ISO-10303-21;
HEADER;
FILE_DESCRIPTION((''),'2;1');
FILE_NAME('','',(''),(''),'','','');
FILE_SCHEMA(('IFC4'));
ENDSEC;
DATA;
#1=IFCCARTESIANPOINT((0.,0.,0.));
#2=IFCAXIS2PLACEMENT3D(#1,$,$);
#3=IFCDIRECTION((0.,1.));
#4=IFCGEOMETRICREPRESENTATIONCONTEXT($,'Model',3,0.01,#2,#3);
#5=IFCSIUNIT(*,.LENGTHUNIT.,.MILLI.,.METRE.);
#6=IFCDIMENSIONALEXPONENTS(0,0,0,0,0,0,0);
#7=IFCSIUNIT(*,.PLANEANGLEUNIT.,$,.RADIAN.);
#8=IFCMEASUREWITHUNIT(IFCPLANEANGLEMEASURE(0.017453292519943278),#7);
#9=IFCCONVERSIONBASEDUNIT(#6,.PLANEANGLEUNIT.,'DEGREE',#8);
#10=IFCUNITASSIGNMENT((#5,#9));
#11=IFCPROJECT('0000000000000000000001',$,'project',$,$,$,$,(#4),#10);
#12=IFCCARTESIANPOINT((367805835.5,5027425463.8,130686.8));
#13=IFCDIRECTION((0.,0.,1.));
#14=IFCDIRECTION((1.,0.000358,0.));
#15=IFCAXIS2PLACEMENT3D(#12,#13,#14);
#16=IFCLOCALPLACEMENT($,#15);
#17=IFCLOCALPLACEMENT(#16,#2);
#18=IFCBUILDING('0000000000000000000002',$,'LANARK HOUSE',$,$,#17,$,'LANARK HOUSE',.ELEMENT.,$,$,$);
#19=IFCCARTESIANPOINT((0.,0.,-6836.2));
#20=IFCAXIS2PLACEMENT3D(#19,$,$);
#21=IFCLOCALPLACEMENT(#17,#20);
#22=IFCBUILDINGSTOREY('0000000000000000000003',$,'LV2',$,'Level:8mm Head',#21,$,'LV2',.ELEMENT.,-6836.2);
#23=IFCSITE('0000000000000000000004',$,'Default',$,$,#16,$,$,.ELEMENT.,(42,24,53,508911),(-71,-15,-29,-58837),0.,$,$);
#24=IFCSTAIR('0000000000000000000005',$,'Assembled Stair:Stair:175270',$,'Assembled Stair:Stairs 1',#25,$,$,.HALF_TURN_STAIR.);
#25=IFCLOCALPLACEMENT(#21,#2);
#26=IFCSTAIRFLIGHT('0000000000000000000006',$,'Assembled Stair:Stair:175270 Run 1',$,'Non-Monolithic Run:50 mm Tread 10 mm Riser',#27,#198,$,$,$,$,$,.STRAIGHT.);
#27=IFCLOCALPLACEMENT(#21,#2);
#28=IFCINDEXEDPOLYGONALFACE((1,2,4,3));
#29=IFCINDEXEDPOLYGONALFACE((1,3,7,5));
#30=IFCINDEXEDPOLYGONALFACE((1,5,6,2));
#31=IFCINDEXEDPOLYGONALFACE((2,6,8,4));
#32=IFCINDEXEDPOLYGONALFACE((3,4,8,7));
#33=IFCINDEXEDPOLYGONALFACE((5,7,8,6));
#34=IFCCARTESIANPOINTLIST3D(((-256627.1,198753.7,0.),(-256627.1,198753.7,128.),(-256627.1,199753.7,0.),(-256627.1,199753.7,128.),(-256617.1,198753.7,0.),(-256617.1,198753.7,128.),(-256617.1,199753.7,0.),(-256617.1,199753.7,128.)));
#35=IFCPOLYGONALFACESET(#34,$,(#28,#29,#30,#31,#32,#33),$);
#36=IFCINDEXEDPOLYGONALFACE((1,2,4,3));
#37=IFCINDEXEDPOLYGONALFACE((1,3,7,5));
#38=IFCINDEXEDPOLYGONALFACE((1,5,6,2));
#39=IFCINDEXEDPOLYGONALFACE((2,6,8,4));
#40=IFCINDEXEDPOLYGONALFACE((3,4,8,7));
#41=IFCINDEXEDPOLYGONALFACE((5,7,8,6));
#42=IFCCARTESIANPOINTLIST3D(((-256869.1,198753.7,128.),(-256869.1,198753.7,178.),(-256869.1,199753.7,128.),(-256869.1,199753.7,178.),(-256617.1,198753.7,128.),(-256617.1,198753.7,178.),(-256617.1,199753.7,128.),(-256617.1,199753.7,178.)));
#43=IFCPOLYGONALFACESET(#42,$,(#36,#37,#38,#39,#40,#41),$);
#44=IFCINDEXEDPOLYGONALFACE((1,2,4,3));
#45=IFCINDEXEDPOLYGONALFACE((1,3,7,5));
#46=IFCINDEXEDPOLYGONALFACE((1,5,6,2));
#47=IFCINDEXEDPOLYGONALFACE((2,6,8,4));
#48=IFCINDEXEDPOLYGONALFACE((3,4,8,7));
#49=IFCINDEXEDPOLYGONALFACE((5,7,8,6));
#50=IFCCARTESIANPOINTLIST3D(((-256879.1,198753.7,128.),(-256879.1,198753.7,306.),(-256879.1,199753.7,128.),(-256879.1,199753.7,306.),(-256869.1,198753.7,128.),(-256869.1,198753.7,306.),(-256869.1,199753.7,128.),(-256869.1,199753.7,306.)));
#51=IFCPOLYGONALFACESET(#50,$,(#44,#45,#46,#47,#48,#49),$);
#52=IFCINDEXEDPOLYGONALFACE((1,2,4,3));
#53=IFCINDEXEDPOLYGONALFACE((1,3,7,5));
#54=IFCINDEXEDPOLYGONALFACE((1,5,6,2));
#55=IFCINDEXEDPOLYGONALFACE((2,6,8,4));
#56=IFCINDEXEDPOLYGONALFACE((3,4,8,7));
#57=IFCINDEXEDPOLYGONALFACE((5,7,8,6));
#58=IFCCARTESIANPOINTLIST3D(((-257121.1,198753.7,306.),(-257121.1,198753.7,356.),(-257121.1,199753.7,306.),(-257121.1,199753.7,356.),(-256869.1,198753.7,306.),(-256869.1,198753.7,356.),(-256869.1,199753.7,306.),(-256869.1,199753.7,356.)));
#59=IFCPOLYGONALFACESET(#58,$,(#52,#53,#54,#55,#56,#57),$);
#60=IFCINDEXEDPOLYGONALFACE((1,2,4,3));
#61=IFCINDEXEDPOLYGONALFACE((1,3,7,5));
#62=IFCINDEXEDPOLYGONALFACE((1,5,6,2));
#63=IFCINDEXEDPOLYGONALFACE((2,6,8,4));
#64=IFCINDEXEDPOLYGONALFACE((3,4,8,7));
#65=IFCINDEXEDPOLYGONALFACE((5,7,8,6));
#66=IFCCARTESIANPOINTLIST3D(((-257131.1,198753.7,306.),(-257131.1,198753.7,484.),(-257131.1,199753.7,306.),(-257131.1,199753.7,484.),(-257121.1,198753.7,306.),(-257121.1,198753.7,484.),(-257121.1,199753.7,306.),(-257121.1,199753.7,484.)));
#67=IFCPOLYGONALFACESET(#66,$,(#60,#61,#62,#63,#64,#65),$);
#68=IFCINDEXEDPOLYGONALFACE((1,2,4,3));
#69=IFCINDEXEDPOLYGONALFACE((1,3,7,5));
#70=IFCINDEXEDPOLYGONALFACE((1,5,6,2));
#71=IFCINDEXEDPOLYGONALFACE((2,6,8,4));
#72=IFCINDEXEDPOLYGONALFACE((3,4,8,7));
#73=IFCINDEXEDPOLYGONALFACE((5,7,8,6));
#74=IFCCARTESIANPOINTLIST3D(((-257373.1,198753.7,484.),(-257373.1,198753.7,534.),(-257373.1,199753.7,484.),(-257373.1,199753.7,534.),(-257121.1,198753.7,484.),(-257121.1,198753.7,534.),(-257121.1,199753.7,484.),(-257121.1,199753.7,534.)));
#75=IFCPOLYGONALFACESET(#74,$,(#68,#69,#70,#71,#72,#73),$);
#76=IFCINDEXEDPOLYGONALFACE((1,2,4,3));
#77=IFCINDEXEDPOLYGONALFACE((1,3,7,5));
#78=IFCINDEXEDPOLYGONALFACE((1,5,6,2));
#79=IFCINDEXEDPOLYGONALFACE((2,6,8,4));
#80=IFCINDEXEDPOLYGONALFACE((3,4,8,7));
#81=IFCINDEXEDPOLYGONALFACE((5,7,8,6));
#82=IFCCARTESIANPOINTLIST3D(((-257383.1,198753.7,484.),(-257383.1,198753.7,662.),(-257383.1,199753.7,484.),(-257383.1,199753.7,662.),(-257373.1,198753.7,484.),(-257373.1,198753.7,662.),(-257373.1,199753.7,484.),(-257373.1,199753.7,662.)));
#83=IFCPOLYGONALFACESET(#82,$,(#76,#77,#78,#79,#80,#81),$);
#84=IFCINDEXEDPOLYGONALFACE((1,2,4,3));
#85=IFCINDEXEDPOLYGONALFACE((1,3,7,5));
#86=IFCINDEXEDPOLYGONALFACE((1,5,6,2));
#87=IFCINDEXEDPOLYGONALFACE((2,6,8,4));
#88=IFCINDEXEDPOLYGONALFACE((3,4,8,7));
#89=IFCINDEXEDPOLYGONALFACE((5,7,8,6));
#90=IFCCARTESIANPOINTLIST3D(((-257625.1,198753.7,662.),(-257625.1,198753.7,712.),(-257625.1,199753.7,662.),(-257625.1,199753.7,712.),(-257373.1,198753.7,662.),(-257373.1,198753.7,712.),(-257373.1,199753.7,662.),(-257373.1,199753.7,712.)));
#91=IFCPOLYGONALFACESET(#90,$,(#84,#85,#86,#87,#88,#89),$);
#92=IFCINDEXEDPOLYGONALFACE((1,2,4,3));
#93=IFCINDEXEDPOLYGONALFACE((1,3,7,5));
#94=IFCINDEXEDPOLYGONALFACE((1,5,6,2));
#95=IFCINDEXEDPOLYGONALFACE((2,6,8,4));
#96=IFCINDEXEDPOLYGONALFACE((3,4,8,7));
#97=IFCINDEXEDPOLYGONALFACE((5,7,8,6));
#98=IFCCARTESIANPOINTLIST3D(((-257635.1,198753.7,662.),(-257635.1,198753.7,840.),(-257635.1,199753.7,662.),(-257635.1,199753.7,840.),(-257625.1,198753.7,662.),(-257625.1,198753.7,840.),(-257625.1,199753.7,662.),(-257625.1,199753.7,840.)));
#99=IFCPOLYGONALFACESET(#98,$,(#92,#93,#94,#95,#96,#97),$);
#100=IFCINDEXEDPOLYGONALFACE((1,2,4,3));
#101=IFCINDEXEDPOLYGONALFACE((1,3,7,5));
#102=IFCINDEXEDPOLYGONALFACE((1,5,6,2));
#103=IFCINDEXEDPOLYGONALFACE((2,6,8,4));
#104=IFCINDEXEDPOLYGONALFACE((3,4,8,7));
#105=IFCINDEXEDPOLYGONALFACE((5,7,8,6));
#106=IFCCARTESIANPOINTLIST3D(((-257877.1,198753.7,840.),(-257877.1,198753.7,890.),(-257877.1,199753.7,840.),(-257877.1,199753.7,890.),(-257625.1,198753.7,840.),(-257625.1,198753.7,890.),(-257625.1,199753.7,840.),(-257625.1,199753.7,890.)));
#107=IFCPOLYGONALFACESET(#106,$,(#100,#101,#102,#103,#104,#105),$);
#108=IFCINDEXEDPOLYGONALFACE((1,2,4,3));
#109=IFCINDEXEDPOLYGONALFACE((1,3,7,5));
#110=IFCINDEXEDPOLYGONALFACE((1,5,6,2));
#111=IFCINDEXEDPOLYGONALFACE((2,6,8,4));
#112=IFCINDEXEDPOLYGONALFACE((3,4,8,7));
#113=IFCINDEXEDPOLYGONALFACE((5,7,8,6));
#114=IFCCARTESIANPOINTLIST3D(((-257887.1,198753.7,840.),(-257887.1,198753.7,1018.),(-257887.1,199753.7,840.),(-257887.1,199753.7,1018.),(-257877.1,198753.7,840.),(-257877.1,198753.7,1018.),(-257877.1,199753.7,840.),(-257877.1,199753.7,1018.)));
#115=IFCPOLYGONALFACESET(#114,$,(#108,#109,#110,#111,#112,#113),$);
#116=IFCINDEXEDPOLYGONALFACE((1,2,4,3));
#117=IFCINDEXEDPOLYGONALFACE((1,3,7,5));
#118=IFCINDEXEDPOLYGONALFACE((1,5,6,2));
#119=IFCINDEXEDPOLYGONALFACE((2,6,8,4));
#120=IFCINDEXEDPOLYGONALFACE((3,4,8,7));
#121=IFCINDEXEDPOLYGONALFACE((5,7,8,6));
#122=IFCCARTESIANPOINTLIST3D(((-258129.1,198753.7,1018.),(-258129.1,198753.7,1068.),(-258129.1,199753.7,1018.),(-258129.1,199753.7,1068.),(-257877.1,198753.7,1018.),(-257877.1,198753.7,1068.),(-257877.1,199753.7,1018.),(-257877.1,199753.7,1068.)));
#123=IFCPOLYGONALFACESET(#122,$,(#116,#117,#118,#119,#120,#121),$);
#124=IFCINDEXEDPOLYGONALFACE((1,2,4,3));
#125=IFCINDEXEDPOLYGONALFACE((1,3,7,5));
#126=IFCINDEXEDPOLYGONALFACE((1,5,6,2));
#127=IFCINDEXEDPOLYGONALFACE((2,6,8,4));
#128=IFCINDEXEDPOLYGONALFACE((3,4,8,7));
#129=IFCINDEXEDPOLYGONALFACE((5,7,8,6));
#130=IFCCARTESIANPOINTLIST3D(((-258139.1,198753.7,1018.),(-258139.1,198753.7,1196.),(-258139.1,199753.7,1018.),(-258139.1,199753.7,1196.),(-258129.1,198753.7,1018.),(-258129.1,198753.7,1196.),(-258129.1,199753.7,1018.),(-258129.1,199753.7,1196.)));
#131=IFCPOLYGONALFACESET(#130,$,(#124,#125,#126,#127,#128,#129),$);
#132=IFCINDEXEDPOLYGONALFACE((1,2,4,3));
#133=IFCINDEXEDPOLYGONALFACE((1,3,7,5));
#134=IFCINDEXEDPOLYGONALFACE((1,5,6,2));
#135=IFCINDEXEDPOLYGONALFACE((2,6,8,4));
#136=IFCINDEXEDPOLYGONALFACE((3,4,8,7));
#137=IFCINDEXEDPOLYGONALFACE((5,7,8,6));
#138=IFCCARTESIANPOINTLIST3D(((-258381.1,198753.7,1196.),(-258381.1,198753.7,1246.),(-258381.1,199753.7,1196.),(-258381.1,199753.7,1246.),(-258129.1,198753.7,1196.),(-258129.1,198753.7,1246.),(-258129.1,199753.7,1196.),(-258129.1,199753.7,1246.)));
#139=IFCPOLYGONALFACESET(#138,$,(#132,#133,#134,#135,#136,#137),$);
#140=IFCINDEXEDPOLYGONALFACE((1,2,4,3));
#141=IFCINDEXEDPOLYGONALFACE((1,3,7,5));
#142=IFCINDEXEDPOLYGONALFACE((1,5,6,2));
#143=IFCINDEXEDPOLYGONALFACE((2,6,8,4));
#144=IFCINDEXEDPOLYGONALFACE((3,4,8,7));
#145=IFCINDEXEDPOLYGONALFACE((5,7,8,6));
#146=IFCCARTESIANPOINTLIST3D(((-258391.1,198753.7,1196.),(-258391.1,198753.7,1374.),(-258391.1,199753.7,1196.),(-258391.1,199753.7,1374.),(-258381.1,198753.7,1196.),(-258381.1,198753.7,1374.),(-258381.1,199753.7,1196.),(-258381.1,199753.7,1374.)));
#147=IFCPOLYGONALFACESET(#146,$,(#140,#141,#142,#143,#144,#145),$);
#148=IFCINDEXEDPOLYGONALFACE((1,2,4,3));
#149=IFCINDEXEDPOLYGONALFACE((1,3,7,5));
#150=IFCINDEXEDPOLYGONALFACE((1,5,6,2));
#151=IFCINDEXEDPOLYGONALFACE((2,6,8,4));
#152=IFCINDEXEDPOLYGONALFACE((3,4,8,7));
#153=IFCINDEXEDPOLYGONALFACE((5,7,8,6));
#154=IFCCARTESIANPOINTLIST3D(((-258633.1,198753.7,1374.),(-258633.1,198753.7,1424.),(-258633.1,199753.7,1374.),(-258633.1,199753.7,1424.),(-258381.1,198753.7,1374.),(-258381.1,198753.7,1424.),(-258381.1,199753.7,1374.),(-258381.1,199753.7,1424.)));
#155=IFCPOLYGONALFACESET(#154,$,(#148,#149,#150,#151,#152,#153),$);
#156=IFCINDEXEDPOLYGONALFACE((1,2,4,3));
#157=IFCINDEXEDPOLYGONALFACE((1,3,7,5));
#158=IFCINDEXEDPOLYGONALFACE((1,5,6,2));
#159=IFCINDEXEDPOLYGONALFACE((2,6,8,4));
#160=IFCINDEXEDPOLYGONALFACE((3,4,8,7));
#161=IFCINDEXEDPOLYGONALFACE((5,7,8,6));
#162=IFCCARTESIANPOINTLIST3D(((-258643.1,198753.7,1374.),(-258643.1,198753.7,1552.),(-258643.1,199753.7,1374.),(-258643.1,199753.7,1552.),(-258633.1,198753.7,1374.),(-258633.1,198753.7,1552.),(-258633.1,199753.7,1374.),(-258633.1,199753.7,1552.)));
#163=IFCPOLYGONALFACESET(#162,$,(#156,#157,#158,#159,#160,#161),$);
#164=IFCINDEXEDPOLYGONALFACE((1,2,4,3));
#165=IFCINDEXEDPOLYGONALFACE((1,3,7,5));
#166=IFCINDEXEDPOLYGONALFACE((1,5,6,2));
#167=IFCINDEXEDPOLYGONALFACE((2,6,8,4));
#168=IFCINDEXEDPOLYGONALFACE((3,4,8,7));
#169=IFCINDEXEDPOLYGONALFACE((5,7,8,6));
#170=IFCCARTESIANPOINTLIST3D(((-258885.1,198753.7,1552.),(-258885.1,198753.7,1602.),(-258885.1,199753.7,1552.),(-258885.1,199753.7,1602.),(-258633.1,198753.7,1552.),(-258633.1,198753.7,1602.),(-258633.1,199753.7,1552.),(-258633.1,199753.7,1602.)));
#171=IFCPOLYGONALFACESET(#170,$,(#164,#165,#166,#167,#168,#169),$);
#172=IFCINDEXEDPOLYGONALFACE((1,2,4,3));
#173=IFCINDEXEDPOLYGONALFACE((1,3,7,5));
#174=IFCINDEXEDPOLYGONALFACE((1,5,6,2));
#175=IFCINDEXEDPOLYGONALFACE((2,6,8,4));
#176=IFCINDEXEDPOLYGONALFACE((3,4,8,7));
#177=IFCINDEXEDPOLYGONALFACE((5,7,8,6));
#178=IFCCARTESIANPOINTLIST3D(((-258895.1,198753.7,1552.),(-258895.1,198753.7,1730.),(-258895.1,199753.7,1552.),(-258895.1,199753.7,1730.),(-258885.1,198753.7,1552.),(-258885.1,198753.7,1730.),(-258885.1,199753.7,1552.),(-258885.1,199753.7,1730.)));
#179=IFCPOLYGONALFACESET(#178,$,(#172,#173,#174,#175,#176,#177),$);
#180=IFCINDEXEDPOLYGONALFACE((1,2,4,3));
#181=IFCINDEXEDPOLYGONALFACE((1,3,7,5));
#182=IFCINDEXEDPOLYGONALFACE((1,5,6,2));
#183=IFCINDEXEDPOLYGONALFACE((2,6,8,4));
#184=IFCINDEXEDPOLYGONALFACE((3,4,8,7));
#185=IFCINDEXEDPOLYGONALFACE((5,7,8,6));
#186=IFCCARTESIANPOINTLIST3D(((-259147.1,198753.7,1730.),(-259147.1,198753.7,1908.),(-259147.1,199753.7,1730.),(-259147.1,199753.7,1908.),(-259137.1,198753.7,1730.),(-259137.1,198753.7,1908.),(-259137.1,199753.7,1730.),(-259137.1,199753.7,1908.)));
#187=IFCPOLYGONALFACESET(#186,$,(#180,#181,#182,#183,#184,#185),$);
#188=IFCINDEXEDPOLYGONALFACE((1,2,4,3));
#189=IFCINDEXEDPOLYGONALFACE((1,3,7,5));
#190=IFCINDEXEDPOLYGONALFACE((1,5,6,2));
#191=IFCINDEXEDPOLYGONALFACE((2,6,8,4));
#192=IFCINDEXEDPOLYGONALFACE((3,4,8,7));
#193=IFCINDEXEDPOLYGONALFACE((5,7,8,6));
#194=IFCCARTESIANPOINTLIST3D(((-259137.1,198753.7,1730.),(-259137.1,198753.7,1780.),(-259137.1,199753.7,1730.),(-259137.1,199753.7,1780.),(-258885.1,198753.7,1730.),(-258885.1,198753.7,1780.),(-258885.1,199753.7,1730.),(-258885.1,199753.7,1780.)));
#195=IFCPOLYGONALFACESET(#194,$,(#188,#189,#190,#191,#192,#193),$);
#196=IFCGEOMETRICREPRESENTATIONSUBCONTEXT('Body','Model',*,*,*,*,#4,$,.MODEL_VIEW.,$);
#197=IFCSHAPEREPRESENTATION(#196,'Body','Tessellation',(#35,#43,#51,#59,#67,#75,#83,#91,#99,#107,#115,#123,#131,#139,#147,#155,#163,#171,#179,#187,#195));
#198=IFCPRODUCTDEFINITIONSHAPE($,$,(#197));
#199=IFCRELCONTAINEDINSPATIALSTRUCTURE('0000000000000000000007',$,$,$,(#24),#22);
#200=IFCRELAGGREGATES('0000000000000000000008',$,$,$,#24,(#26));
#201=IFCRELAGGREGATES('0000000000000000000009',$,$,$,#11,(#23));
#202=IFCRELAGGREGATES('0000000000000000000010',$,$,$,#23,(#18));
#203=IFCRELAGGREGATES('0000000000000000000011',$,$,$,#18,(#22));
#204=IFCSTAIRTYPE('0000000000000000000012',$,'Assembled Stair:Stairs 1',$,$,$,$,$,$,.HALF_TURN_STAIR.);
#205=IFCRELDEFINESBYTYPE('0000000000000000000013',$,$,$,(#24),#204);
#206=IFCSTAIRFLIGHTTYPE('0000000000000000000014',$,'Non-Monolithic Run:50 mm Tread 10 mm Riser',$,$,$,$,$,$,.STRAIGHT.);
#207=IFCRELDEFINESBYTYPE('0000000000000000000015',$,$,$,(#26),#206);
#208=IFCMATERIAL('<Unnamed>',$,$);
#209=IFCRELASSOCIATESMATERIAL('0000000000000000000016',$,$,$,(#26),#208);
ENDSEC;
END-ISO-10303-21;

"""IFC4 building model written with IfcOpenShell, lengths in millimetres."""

from ifc_helpers import new_model, entity, si_unit, converted_unit, direction, frame, origin, place, context, subcontext, project, spatial, indexed_curve, outline, extrude, material, type_object, element, aggregate, save


model = new_model("IFC4")

# Units and contexts
model_context = context("Model", 3, precision=0.01, world=origin(), true_north=direction((0.0, 1.0)))
body_context = subcontext(model_context, "Body", "Model", "MODEL_VIEW")
ifc_project = project(units=[si_unit("LENGTHUNIT", "METRE", prefix="MILLI"), converted_unit("PLANEANGLEUNIT", "DEGREE", entity("IfcPlaneAngleMeasure", 0.017453292519943278), si_unit("PLANEANGLEUNIT", "RADIAN"), dimensions=[0, 0, 0, 0, 0, 0, 0])], contexts=[model_context])

# Site, building, storey
site_placement = place(None, frame((367805835.5, 5027425463.8, 130686.8), z_axis=(0.0, 0.0, 1.0), x_axis=(1.0, 0.000358, 0.0)))
site = spatial("IfcSite", under=ifc_project, at=site_placement, Name="Default", CompositionType="ELEMENT", RefLatitude=(42, 24, 53, 508911), RefLongitude=(-71, -15, -29, -58837), RefElevation=0.0)
building_placement = place(site_placement, origin())
building = spatial("IfcBuilding", under=site, at=building_placement, Name="LANARK HOUSE", LongName="LANARK HOUSE", CompositionType="ELEMENT")
storey_placement = place(building_placement, frame((0.0, 0.0, -6836.2)))
storey = spatial("IfcBuildingStorey", under=building, at=storey_placement, Name="LV2", ObjectType="Level:8mm Head", LongName="LV2", CompositionType="ELEMENT", Elevation=-6836.2)

# Stair
stair_type = type_object("IfcStairType", Name="Assembled Stair:Stairs 1", PredefinedType="HALF_TURN_STAIR")
stair_placement = place(storey_placement, origin())
stair = element("IfcStair", 1, at=stair_placement, inside=storey, type_object=stair_type, Name="Assembled Stair:Stair:175270", ObjectType="Assembled Stair:Stairs 1", PredefinedType="HALF_TURN_STAIR")
ifc_material_1 = material(Name="<Unnamed>")

# Stair flight
stair_flight_type = type_object("IfcStairFlightType", Name="Non-Monolithic Run:50 mm Tread 10 mm Riser", PredefinedType="STRAIGHT")
stair_flight_placement = place(stair_placement, frame((-259147.1, 198753.7, 0.0)))
stair_flight = element("IfcStairFlight", 2, at=stair_flight_placement, type_object=stair_flight_type, material=ifc_material_1, Name="Assembled Stair:Stair:175270 Run 1", ObjectType="Non-Monolithic Run:50 mm Tread 10 mm Riser", PredefinedType="STRAIGHT", context=body_context, shape_type="SweptSolid", body=[
    extrude(outline(indexed_curve([(-500.0, -5.0), (500.0, -5.0), (500.0, 5.0), (-500.0, 5.0), (-500.0, -5.0)], self_intersect=False)), frame((2525.0, 500.0, 0.0), z_axis=(0.0, 0.0, 1.0), x_axis=(0.0, -1.0, 0.0)), (0.0, 0.0, 1.0), 128.0),
    extrude(outline(indexed_curve([(-126.0, -500.0), (126.0, -500.0), (126.0, 500.0), (-126.0, 500.0), (-126.0, -500.0)], self_intersect=False)), frame((2404.0, 500.0, 128.0)), (0.0, 0.0, 1.0), 50.0),
    extrude(outline(indexed_curve([(-500.0, -5.0), (500.0, -5.0), (500.0, 5.0), (-500.0, 5.0), (-500.0, -5.0)], self_intersect=False)), frame((2273.0, 500.0, 128.0), z_axis=(0.0, 0.0, 1.0), x_axis=(0.0, -1.0, 0.0)), (0.0, 0.0, 1.0), 178.0),
    extrude(outline(indexed_curve([(-126.0, -500.0), (126.0, -500.0), (126.0, 500.0), (-126.0, 500.0), (-126.0, -500.0)], self_intersect=False)), frame((2152.0, 500.0, 306.0)), (0.0, 0.0, 1.0), 50.0),
    extrude(outline(indexed_curve([(-500.0, -5.0), (500.0, -5.0), (500.0, 5.0), (-500.0, 5.0), (-500.0, -5.0)], self_intersect=False)), frame((2021.0, 500.0, 306.0), z_axis=(0.0, 0.0, 1.0), x_axis=(0.0, -1.0, 0.0)), (0.0, 0.0, 1.0), 178.0),
    extrude(outline(indexed_curve([(-126.0, -500.0), (126.0, -500.0), (126.0, 500.0), (-126.0, 500.0), (-126.0, -500.0)], self_intersect=False)), frame((1900.0, 500.0, 484.0)), (0.0, 0.0, 1.0), 50.0),
    extrude(outline(indexed_curve([(-500.0, -5.0), (500.0, -5.0), (500.0, 5.0), (-500.0, 5.0), (-500.0, -5.0)], self_intersect=False)), frame((1769.0, 500.0, 484.0), z_axis=(0.0, 0.0, 1.0), x_axis=(0.0, -1.0, 0.0)), (0.0, 0.0, 1.0), 178.0),
    extrude(outline(indexed_curve([(-126.0, -500.0), (126.0, -500.0), (126.0, 500.0), (-126.0, 500.0), (-126.0, -500.0)], self_intersect=False)), frame((1648.0, 500.0, 662.0)), (0.0, 0.0, 1.0), 50.0),
    extrude(outline(indexed_curve([(-500.0, -5.0), (500.0, -5.0), (500.0, 5.0), (-500.0, 5.0), (-500.0, -5.0)], self_intersect=False)), frame((1517.0, 500.0, 662.0), z_axis=(0.0, 0.0, 1.0), x_axis=(0.0, -1.0, 0.0)), (0.0, 0.0, 1.0), 178.0),
    extrude(outline(indexed_curve([(-126.0, -500.0), (126.0, -500.0), (126.0, 500.0), (-126.0, 500.0), (-126.0, -500.0)], self_intersect=False)), frame((1396.0, 500.0, 840.0)), (0.0, 0.0, 1.0), 50.0),
    extrude(outline(indexed_curve([(-500.0, -5.0), (500.0, -5.0), (500.0, 5.0), (-500.0, 5.0), (-500.0, -5.0)], self_intersect=False)), frame((1265.0, 500.0, 840.0), z_axis=(0.0, 0.0, 1.0), x_axis=(0.0, -1.0, 0.0)), (0.0, 0.0, 1.0), 178.0),
    extrude(outline(indexed_curve([(-126.0, -500.0), (126.0, -500.0), (126.0, 500.0), (-126.0, 500.0), (-126.0, -500.0)], self_intersect=False)), frame((1144.0, 500.0, 1018.0)), (0.0, 0.0, 1.0), 50.0),
    extrude(outline(indexed_curve([(-500.0, -5.0), (500.0, -5.0), (500.0, 5.0), (-500.0, 5.0), (-500.0, -5.0)], self_intersect=False)), frame((1013.0, 500.0, 1018.0), z_axis=(0.0, 0.0, 1.0), x_axis=(0.0, -1.0, 0.0)), (0.0, 0.0, 1.0), 178.0),
    extrude(outline(indexed_curve([(-126.0, -500.0), (126.0, -500.0), (126.0, 500.0), (-126.0, 500.0), (-126.0, -500.0)], self_intersect=False)), frame((892.0, 500.0, 1196.0)), (0.0, 0.0, 1.0), 50.0),
    extrude(outline(indexed_curve([(-500.0, -5.0), (500.0, -5.0), (500.0, 5.0), (-500.0, 5.0), (-500.0, -5.0)], self_intersect=False)), frame((761.0, 500.0, 1196.0), z_axis=(0.0, 0.0, 1.0), x_axis=(0.0, -1.0, 0.0)), (0.0, 0.0, 1.0), 178.0),
    extrude(outline(indexed_curve([(-126.0, -500.0), (126.0, -500.0), (126.0, 500.0), (-126.0, 500.0), (-126.0, -500.0)], self_intersect=False)), frame((640.0, 500.0, 1374.0)), (0.0, 0.0, 1.0), 50.0),
    extrude(outline(indexed_curve([(-500.0, -5.0), (500.0, -5.0), (500.0, 5.0), (-500.0, 5.0), (-500.0, -5.0)], self_intersect=False)), frame((509.0, 500.0, 1374.0), z_axis=(0.0, 0.0, 1.0), x_axis=(0.0, -1.0, 0.0)), (0.0, 0.0, 1.0), 178.0),
    extrude(outline(indexed_curve([(-126.0, -500.0), (126.0, -500.0), (126.0, 500.0), (-126.0, 500.0), (-126.0, -500.0)], self_intersect=False)), frame((388.0, 500.0, 1552.0)), (0.0, 0.0, 1.0), 50.0),
    extrude(outline(indexed_curve([(-500.0, -5.0), (500.0, -5.0), (500.0, 5.0), (-500.0, 5.0), (-500.0, -5.0)], self_intersect=False)), frame((257.0, 500.0, 1552.0), z_axis=(0.0, 0.0, 1.0), x_axis=(0.0, -1.0, 0.0)), (0.0, 0.0, 1.0), 178.0),
    extrude(outline(indexed_curve([(-500.0, -5.0), (500.0, -5.0), (500.0, 5.0), (-500.0, 5.0), (-500.0, -5.0)], self_intersect=False)), frame((5.0, 500.0, 1730.0), z_axis=(0.0, 0.0, 1.0), x_axis=(0.0, -1.0, 0.0)), (0.0, 0.0, 1.0), 178.0),
    extrude(outline(indexed_curve([(-126.0, -500.0), (126.0, -500.0), (126.0, 500.0), (-126.0, 500.0), (-126.0, -500.0)], self_intersect=False)), frame((136.0, 500.0, 1730.0)), (0.0, 0.0, 1.0), 50.0),
])

aggregate(stair, [stair_flight])

save(model, "model.ifc")
